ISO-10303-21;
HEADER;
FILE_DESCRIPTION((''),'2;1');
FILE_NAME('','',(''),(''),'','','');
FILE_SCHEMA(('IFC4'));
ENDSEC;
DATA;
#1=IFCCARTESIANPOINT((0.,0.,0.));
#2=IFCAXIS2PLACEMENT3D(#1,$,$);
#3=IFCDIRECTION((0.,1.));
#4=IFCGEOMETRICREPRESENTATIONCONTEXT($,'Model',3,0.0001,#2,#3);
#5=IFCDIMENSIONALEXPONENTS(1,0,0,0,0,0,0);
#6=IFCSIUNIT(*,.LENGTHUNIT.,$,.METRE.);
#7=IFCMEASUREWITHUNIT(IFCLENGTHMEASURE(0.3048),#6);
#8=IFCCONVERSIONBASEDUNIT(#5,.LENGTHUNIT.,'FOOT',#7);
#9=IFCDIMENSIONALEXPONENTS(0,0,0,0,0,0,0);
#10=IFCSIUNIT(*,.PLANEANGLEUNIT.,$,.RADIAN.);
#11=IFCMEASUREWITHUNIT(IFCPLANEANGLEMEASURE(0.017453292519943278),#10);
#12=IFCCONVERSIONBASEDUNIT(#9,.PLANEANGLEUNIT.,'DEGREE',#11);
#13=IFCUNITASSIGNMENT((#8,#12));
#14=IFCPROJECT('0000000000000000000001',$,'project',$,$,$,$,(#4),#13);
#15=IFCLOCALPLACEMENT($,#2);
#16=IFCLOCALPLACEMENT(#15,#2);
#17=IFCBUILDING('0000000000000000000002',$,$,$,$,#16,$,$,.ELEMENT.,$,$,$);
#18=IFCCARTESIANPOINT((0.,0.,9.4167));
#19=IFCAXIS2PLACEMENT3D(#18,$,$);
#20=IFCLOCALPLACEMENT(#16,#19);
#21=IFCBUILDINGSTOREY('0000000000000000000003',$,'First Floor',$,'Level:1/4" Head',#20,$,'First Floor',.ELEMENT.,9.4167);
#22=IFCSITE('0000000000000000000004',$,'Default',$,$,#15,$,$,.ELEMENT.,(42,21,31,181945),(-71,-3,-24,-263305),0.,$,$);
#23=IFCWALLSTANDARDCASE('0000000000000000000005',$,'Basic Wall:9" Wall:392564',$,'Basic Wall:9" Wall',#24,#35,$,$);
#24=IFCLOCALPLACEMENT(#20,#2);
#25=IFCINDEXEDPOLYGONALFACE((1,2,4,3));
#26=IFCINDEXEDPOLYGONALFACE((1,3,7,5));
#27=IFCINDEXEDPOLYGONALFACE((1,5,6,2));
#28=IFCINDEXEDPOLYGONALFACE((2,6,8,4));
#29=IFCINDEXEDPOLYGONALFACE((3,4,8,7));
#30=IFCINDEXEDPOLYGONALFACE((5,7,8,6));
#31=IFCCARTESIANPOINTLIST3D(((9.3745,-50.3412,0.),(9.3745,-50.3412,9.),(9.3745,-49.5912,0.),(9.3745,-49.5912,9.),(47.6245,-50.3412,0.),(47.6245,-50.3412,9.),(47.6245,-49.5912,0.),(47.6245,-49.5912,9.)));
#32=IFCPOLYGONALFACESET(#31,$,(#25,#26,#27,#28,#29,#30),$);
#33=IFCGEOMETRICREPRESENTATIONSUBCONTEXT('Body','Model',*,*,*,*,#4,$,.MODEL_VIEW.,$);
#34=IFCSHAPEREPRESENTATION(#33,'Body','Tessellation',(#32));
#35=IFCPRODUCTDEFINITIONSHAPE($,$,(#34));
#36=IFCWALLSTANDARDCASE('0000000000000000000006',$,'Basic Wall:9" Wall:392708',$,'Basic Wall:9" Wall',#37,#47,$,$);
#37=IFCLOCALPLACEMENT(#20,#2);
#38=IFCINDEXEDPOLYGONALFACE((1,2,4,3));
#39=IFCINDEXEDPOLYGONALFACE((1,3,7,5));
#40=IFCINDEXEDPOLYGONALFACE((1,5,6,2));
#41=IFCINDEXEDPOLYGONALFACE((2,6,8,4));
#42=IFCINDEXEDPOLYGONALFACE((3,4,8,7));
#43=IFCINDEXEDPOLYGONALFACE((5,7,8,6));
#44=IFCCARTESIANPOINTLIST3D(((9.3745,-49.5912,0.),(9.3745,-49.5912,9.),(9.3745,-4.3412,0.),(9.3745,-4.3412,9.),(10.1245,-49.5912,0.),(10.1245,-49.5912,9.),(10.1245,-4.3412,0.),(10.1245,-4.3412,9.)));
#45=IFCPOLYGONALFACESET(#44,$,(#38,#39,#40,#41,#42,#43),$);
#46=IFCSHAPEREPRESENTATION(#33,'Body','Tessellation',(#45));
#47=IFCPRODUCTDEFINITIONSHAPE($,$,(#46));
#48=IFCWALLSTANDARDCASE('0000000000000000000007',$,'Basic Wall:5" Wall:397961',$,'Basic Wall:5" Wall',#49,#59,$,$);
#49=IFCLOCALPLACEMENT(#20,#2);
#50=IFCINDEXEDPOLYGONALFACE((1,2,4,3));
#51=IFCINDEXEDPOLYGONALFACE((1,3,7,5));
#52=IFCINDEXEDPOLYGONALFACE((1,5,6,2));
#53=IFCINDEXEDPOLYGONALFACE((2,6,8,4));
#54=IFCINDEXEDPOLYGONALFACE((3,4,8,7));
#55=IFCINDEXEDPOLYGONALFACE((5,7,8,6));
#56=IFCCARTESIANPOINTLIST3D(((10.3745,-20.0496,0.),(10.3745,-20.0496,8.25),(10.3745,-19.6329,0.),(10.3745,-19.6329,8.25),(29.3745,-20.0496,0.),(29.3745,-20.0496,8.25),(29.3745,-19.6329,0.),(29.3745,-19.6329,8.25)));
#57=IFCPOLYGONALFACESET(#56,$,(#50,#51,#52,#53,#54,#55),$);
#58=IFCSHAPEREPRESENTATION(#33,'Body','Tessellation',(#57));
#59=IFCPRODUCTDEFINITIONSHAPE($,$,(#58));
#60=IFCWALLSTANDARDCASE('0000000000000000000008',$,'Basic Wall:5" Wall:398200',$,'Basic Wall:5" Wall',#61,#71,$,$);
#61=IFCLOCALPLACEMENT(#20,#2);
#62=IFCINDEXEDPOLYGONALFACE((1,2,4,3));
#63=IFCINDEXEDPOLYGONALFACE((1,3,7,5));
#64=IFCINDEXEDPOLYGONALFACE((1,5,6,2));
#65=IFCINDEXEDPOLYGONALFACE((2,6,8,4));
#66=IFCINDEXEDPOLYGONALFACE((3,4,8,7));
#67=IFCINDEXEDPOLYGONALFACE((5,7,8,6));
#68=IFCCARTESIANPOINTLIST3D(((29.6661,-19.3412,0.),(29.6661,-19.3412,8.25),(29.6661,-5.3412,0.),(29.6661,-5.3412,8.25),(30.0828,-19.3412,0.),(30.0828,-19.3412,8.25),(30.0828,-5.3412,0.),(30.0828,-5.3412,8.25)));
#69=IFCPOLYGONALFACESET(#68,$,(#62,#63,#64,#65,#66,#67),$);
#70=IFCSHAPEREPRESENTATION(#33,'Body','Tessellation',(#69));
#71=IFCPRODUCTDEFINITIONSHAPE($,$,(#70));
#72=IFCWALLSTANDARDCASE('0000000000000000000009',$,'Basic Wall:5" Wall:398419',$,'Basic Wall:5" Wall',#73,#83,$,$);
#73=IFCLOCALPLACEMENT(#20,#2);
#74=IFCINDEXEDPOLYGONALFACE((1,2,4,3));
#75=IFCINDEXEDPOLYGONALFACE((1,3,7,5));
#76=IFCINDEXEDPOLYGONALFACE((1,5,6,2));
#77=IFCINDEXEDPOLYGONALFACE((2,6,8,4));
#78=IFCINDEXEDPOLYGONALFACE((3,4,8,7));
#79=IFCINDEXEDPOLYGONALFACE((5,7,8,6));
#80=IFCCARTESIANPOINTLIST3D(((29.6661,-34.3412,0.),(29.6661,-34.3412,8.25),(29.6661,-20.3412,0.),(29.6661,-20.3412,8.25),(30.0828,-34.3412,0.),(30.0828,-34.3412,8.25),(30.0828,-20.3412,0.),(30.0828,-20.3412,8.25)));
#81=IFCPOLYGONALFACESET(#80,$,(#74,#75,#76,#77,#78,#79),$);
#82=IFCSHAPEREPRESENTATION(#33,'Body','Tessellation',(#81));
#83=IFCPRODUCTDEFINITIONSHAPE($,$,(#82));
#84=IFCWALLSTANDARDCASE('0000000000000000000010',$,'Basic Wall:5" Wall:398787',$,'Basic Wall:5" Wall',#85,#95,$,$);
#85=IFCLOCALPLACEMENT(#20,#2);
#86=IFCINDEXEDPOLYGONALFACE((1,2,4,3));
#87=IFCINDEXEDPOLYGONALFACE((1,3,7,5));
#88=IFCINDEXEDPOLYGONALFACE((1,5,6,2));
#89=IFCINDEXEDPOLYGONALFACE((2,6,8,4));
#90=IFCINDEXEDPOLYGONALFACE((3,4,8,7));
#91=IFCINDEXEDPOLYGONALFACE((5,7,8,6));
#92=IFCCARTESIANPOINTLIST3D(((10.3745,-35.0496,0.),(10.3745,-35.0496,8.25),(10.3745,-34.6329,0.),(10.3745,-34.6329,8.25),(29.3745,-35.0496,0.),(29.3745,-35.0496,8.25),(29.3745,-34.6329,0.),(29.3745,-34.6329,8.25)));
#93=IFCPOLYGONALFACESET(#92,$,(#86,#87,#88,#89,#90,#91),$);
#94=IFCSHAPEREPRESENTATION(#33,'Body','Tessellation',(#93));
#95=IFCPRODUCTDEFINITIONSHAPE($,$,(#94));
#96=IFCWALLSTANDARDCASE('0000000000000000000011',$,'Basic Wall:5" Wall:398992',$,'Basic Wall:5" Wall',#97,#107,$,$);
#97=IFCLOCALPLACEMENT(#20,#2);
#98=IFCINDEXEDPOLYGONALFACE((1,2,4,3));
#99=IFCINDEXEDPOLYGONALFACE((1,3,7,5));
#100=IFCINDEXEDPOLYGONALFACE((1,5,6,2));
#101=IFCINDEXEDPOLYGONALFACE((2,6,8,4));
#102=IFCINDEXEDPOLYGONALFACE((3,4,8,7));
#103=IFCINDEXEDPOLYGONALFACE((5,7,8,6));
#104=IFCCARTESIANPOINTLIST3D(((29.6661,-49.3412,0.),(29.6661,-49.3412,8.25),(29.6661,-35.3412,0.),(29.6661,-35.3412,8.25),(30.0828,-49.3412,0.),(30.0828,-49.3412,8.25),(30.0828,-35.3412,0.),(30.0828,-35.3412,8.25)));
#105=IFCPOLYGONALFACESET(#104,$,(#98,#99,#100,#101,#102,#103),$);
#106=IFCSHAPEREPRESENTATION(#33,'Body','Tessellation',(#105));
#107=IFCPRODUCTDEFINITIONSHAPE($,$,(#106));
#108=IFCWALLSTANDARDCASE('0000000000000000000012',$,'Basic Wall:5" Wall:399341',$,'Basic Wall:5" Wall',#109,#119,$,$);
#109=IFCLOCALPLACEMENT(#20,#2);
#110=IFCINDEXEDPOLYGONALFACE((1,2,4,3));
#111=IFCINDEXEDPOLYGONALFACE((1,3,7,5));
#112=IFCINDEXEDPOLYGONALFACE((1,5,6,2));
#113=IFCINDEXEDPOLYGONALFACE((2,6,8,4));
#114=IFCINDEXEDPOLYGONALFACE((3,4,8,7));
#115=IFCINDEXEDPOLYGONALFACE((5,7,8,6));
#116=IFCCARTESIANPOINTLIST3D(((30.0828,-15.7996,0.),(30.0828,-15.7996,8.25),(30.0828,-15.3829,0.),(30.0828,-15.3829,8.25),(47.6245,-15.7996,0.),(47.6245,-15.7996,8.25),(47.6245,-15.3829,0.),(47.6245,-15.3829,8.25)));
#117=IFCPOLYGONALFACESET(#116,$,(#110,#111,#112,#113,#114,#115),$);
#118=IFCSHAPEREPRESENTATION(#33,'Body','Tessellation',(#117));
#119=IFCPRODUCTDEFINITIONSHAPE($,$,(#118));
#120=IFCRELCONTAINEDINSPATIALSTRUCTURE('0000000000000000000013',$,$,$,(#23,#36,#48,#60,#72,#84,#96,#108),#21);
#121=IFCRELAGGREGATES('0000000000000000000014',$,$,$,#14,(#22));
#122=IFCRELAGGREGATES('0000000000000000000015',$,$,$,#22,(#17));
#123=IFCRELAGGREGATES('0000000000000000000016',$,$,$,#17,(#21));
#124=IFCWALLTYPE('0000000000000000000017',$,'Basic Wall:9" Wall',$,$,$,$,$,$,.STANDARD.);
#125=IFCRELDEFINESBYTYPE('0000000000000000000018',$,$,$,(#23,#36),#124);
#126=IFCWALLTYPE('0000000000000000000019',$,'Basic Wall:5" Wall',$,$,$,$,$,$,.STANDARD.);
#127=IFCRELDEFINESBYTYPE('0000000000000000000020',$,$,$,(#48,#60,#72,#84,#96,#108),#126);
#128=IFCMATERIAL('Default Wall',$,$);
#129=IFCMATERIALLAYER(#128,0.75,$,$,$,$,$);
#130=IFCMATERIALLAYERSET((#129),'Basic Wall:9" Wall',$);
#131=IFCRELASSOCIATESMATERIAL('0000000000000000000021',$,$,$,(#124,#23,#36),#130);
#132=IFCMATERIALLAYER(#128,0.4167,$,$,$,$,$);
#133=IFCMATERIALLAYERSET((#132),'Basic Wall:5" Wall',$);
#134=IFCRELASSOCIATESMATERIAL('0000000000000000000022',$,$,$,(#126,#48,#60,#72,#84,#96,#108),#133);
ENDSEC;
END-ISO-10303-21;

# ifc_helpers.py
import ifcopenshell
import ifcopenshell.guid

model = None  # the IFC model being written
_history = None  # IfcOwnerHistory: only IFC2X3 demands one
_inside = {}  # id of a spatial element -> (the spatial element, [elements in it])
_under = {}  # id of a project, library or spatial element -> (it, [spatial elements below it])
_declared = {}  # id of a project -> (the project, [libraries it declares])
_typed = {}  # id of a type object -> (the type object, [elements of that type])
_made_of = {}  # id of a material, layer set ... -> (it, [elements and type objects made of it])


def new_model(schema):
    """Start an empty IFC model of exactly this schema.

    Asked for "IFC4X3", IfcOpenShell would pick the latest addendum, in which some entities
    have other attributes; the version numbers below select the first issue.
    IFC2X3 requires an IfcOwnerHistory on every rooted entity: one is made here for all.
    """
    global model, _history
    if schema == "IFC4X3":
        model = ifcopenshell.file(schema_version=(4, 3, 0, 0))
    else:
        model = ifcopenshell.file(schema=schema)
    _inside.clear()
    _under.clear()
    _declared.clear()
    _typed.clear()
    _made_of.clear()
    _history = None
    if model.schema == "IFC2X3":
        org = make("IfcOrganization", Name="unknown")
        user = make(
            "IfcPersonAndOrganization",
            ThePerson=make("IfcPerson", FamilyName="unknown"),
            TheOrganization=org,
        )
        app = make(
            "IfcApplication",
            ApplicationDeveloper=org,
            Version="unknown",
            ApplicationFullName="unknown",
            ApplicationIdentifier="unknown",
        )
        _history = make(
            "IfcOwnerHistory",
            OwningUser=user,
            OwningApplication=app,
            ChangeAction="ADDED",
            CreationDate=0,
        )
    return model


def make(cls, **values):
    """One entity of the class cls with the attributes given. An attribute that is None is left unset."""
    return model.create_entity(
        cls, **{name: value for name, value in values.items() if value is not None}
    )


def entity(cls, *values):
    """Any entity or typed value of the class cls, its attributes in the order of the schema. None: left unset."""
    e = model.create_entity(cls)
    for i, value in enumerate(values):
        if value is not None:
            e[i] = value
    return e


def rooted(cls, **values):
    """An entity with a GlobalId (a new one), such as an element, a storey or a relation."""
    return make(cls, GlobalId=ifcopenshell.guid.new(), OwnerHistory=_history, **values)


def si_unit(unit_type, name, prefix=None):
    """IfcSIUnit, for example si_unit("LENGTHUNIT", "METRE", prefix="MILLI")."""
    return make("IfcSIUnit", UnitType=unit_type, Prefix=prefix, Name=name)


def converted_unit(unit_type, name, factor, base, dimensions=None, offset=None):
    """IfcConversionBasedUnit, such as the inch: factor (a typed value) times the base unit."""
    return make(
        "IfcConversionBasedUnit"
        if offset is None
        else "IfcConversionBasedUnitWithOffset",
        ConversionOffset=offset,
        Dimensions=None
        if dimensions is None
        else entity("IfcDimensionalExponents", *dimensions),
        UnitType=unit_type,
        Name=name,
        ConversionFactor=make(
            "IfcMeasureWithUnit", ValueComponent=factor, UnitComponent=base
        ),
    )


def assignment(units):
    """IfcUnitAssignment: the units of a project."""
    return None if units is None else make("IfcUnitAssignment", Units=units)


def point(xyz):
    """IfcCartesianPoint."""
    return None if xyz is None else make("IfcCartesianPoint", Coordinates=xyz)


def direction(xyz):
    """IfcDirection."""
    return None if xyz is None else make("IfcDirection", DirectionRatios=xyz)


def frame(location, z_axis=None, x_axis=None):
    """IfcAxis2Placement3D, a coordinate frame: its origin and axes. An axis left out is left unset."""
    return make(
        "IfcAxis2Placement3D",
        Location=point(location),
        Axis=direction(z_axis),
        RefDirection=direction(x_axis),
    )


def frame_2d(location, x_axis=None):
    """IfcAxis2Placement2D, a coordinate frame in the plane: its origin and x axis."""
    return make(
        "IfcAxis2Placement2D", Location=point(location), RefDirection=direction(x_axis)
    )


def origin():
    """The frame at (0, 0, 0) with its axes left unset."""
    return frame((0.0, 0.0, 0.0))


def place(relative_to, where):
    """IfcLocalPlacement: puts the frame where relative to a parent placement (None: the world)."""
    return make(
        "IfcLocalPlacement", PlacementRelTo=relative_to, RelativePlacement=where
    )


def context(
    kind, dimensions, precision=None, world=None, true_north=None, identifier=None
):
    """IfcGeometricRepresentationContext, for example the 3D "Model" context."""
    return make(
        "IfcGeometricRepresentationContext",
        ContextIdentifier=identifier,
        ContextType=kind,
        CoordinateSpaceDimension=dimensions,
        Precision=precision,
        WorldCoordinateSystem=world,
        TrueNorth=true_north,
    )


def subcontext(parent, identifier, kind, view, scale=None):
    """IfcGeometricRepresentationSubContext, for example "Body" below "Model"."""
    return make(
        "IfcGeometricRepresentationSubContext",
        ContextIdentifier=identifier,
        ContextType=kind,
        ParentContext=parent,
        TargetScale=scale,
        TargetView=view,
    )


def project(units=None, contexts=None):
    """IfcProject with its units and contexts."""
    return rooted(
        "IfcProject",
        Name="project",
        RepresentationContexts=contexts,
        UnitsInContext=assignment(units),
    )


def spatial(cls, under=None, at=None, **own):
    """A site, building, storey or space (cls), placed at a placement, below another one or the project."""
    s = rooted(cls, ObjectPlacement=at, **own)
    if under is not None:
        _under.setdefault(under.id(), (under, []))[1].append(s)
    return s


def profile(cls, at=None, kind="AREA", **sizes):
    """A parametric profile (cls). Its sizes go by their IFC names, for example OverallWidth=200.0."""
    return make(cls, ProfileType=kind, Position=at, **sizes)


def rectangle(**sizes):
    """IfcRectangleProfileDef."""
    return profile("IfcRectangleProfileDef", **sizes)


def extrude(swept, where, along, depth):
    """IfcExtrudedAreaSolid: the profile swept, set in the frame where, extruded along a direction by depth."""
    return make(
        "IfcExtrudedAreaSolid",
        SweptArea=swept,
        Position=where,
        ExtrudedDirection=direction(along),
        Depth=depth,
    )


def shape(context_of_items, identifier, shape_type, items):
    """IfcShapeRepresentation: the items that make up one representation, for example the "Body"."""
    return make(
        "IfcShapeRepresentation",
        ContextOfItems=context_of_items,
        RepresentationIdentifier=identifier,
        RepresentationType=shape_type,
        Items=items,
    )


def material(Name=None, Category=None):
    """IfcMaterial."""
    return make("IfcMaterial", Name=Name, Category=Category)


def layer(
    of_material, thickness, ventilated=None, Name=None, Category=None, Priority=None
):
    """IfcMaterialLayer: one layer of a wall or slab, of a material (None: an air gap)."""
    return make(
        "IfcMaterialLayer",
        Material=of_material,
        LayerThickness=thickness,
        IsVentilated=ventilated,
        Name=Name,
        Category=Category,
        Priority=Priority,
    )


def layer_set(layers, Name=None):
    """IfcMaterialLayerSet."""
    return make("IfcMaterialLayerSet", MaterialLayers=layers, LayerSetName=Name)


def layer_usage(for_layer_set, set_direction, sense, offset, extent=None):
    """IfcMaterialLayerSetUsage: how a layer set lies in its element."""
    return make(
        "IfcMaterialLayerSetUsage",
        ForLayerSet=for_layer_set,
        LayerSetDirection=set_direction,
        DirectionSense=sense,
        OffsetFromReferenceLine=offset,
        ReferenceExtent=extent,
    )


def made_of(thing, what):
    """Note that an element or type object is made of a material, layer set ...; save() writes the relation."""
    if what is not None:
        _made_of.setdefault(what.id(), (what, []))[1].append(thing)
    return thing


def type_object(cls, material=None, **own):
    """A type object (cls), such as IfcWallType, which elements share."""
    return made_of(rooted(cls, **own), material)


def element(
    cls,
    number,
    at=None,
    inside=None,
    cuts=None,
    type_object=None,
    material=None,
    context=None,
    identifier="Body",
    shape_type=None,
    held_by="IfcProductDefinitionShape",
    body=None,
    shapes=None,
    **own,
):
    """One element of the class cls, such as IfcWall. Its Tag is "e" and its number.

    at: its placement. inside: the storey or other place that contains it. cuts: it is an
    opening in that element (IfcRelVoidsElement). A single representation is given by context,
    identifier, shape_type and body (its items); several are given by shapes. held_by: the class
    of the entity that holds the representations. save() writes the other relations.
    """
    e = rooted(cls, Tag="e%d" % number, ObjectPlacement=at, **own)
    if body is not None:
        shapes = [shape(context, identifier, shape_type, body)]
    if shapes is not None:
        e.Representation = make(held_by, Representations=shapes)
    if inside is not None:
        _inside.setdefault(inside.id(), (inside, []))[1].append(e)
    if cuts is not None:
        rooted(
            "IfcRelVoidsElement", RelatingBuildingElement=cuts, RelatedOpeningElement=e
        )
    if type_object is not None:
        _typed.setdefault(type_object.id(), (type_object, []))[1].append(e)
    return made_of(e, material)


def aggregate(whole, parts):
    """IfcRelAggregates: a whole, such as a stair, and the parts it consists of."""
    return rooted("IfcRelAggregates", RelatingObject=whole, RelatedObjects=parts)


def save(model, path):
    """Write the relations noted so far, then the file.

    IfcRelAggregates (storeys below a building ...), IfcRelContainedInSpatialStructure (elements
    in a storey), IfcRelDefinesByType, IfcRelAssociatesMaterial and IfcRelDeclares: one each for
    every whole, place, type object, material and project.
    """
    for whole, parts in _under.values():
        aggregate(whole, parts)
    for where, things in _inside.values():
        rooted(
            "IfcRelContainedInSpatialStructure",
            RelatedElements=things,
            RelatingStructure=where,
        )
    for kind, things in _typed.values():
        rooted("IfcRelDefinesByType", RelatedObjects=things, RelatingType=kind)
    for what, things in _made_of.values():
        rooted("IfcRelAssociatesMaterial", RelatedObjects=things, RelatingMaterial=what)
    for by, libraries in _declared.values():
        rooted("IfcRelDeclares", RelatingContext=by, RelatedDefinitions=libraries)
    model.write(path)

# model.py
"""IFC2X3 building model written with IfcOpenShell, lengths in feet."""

from ifc_helpers import new_model, entity, si_unit, converted_unit, direction, frame, frame_2d, origin, place, context, subcontext, project, spatial, rectangle, extrude, material, layer, layer_set, layer_usage, type_object, element, save


model = new_model("IFC2X3")

# Units and contexts
model_context = context("Model", 3, precision=0.0001, world=origin(), true_north=direction((0.0, 1.0)))
body_context = subcontext(model_context, "Body", "Model", "MODEL_VIEW")
ifc_project = project(units=[converted_unit("LENGTHUNIT", "FOOT", entity("IfcLengthMeasure", 0.3048), si_unit("LENGTHUNIT", "METRE"), dimensions=[1, 0, 0, 0, 0, 0, 0]), converted_unit("PLANEANGLEUNIT", "DEGREE", entity("IfcPlaneAngleMeasure", 0.017453292519943278), si_unit("PLANEANGLEUNIT", "RADIAN"), dimensions=[0, 0, 0, 0, 0, 0, 0])], contexts=[model_context])

# Site, building, storey
site_placement = place(None, origin())
site = spatial("IfcSite", under=ifc_project, at=site_placement, Name="Default", CompositionType="ELEMENT", RefLatitude=(42, 21, 31, 181945), RefLongitude=(-71, -3, -24, -263305), RefElevation=0.0)
building_placement = place(site_placement, origin())
building = spatial("IfcBuilding", under=site, at=building_placement, CompositionType="ELEMENT")
storey_placement = place(building_placement, frame((0.0, 0.0, 9.4167)))
storey = spatial("IfcBuildingStorey", under=building, at=storey_placement, Name="First Floor", ObjectType="Level:1/4\" Head", LongName="First Floor", CompositionType="ELEMENT", Elevation=9.4167)

# Walls
ifc_material_1 = material(Name="Default Wall")
ifc_layer_1 = layer(ifc_material_1, 0.75)
ifc_layer_set_1 = layer_set([ifc_layer_1], Name="Basic Wall:9\" Wall")
ifc_layer_usage_1 = layer_usage(ifc_layer_set_1, "AXIS2", "NEGATIVE", 0.375)
wall_type_1 = type_object("IfcWallType", Name="Basic Wall:9\" Wall", PredefinedType="STANDARD", material=ifc_layer_set_1)
wall_1_placement = place(storey_placement, frame((47.6245, -49.9662, 0.0), z_axis=(0.0, 0.0, 1.0), x_axis=(-1.0, 0.0, 0.0)))
element("IfcWallStandardCase", 1, at=wall_1_placement, inside=storey, type_object=wall_type_1, material=ifc_layer_usage_1, Name="Basic Wall:9\" Wall:392564", ObjectType="Basic Wall:9\" Wall", context=body_context, shape_type="SweptSolid", body=[
    extrude(rectangle(XDim=38.25, YDim=0.75, at=frame_2d((19.125, 0.0), x_axis=(-1.0, 0.0))), origin(), (0.0, 0.0, 1.0), 9.0),
])
wall_2_placement = place(storey_placement, frame((9.7495, -49.5912, 0.0), z_axis=(0.0, 0.0, 1.0), x_axis=(0.0, 1.0, 0.0)))
element("IfcWallStandardCase", 2, at=wall_2_placement, inside=storey, type_object=wall_type_1, material=ifc_layer_usage_1, Name="Basic Wall:9\" Wall:392708", ObjectType="Basic Wall:9\" Wall", context=body_context, shape_type="SweptSolid", body=[
    extrude(rectangle(XDim=45.25, YDim=0.75, at=frame_2d((22.625, 0.0), x_axis=(-1.0, 0.0))), origin(), (0.0, 0.0, 1.0), 9.0),
])
ifc_layer_2 = layer(ifc_material_1, 0.4167)
ifc_layer_set_2 = layer_set([ifc_layer_2], Name="Basic Wall:5\" Wall")
ifc_layer_usage_2 = layer_usage(ifc_layer_set_2, "AXIS2", "NEGATIVE", 0.2083)
wall_type_2 = type_object("IfcWallType", Name="Basic Wall:5\" Wall", PredefinedType="STANDARD", material=ifc_layer_set_2)
wall_3_placement = place(storey_placement, frame((10.3745, -19.8412, 0.0)))
element("IfcWallStandardCase", 3, at=wall_3_placement, inside=storey, type_object=wall_type_2, material=ifc_layer_usage_2, Name="Basic Wall:5\" Wall:397961", ObjectType="Basic Wall:5\" Wall", context=body_context, shape_type="SweptSolid", body=[
    extrude(rectangle(XDim=19.0, YDim=0.4167, at=frame_2d((9.5, 0.0), x_axis=(-1.0, 0.0))), origin(), (0.0, 0.0, 1.0), 8.25),
])
wall_4_placement = place(storey_placement, frame((29.8745, -19.3412, 0.0), z_axis=(0.0, 0.0, 1.0), x_axis=(0.0, 1.0, 0.0)))
element("IfcWallStandardCase", 4, at=wall_4_placement, inside=storey, type_object=wall_type_2, material=ifc_layer_usage_2, Name="Basic Wall:5\" Wall:398200", ObjectType="Basic Wall:5\" Wall", context=body_context, shape_type="SweptSolid", body=[
    extrude(rectangle(XDim=14.0, YDim=0.4167, at=frame_2d((7.0, 0.0), x_axis=(-1.0, 0.0))), origin(), (0.0, 0.0, 1.0), 8.25),
])
wall_5_placement = place(storey_placement, frame((29.8745, -20.3412, 0.0), z_axis=(0.0, 0.0, 1.0), x_axis=(0.0, -1.0, 0.0)))
element("IfcWallStandardCase", 5, at=wall_5_placement, inside=storey, type_object=wall_type_2, material=ifc_layer_usage_2, Name="Basic Wall:5\" Wall:398419", ObjectType="Basic Wall:5\" Wall", context=body_context, shape_type="SweptSolid", body=[
    extrude(rectangle(XDim=14.0, YDim=0.4167, at=frame_2d((7.0, 0.0), x_axis=(-1.0, 0.0))), origin(), (0.0, 0.0, 1.0), 8.25),
])
wall_6_placement = place(storey_placement, frame((29.3745, -34.8412, 0.0), z_axis=(0.0, 0.0, 1.0), x_axis=(-1.0, 0.0, 0.0)))
element("IfcWallStandardCase", 6, at=wall_6_placement, inside=storey, type_object=wall_type_2, material=ifc_layer_usage_2, Name="Basic Wall:5\" Wall:398787", ObjectType="Basic Wall:5\" Wall", context=body_context, shape_type="SweptSolid", body=[
    extrude(rectangle(XDim=19.0, YDim=0.4167, at=frame_2d((9.5, 0.0), x_axis=(-1.0, 0.0))), origin(), (0.0, 0.0, 1.0), 8.25),
])
wall_7_placement = place(storey_placement, frame((29.8745, -35.3412, 0.0), z_axis=(0.0, 0.0, 1.0), x_axis=(0.0, -1.0, 0.0)))
element("IfcWallStandardCase", 7, at=wall_7_placement, inside=storey, type_object=wall_type_2, material=ifc_layer_usage_2, Name="Basic Wall:5\" Wall:398992", ObjectType="Basic Wall:5\" Wall", context=body_context, shape_type="SweptSolid", body=[
    extrude(rectangle(XDim=14.0, YDim=0.4167, at=frame_2d((7.0, 0.0), x_axis=(-1.0, 0.0))), origin(), (0.0, 0.0, 1.0), 8.25),
])
wall_8_placement = place(storey_placement, frame((30.0828, -15.5912, 0.0)))
element("IfcWallStandardCase", 8, at=wall_8_placement, inside=storey, type_object=wall_type_2, material=ifc_layer_usage_2, Name="Basic Wall:5\" Wall:399341", ObjectType="Basic Wall:5\" Wall", context=body_context, shape_type="SweptSolid", body=[
    extrude(rectangle(XDim=17.5417, YDim=0.4167, at=frame_2d((8.7708, 0.0), x_axis=(-1.0, 0.0))), origin(), (0.0, 0.0, 1.0), 8.25),
])

save(model, "model.ifc")
